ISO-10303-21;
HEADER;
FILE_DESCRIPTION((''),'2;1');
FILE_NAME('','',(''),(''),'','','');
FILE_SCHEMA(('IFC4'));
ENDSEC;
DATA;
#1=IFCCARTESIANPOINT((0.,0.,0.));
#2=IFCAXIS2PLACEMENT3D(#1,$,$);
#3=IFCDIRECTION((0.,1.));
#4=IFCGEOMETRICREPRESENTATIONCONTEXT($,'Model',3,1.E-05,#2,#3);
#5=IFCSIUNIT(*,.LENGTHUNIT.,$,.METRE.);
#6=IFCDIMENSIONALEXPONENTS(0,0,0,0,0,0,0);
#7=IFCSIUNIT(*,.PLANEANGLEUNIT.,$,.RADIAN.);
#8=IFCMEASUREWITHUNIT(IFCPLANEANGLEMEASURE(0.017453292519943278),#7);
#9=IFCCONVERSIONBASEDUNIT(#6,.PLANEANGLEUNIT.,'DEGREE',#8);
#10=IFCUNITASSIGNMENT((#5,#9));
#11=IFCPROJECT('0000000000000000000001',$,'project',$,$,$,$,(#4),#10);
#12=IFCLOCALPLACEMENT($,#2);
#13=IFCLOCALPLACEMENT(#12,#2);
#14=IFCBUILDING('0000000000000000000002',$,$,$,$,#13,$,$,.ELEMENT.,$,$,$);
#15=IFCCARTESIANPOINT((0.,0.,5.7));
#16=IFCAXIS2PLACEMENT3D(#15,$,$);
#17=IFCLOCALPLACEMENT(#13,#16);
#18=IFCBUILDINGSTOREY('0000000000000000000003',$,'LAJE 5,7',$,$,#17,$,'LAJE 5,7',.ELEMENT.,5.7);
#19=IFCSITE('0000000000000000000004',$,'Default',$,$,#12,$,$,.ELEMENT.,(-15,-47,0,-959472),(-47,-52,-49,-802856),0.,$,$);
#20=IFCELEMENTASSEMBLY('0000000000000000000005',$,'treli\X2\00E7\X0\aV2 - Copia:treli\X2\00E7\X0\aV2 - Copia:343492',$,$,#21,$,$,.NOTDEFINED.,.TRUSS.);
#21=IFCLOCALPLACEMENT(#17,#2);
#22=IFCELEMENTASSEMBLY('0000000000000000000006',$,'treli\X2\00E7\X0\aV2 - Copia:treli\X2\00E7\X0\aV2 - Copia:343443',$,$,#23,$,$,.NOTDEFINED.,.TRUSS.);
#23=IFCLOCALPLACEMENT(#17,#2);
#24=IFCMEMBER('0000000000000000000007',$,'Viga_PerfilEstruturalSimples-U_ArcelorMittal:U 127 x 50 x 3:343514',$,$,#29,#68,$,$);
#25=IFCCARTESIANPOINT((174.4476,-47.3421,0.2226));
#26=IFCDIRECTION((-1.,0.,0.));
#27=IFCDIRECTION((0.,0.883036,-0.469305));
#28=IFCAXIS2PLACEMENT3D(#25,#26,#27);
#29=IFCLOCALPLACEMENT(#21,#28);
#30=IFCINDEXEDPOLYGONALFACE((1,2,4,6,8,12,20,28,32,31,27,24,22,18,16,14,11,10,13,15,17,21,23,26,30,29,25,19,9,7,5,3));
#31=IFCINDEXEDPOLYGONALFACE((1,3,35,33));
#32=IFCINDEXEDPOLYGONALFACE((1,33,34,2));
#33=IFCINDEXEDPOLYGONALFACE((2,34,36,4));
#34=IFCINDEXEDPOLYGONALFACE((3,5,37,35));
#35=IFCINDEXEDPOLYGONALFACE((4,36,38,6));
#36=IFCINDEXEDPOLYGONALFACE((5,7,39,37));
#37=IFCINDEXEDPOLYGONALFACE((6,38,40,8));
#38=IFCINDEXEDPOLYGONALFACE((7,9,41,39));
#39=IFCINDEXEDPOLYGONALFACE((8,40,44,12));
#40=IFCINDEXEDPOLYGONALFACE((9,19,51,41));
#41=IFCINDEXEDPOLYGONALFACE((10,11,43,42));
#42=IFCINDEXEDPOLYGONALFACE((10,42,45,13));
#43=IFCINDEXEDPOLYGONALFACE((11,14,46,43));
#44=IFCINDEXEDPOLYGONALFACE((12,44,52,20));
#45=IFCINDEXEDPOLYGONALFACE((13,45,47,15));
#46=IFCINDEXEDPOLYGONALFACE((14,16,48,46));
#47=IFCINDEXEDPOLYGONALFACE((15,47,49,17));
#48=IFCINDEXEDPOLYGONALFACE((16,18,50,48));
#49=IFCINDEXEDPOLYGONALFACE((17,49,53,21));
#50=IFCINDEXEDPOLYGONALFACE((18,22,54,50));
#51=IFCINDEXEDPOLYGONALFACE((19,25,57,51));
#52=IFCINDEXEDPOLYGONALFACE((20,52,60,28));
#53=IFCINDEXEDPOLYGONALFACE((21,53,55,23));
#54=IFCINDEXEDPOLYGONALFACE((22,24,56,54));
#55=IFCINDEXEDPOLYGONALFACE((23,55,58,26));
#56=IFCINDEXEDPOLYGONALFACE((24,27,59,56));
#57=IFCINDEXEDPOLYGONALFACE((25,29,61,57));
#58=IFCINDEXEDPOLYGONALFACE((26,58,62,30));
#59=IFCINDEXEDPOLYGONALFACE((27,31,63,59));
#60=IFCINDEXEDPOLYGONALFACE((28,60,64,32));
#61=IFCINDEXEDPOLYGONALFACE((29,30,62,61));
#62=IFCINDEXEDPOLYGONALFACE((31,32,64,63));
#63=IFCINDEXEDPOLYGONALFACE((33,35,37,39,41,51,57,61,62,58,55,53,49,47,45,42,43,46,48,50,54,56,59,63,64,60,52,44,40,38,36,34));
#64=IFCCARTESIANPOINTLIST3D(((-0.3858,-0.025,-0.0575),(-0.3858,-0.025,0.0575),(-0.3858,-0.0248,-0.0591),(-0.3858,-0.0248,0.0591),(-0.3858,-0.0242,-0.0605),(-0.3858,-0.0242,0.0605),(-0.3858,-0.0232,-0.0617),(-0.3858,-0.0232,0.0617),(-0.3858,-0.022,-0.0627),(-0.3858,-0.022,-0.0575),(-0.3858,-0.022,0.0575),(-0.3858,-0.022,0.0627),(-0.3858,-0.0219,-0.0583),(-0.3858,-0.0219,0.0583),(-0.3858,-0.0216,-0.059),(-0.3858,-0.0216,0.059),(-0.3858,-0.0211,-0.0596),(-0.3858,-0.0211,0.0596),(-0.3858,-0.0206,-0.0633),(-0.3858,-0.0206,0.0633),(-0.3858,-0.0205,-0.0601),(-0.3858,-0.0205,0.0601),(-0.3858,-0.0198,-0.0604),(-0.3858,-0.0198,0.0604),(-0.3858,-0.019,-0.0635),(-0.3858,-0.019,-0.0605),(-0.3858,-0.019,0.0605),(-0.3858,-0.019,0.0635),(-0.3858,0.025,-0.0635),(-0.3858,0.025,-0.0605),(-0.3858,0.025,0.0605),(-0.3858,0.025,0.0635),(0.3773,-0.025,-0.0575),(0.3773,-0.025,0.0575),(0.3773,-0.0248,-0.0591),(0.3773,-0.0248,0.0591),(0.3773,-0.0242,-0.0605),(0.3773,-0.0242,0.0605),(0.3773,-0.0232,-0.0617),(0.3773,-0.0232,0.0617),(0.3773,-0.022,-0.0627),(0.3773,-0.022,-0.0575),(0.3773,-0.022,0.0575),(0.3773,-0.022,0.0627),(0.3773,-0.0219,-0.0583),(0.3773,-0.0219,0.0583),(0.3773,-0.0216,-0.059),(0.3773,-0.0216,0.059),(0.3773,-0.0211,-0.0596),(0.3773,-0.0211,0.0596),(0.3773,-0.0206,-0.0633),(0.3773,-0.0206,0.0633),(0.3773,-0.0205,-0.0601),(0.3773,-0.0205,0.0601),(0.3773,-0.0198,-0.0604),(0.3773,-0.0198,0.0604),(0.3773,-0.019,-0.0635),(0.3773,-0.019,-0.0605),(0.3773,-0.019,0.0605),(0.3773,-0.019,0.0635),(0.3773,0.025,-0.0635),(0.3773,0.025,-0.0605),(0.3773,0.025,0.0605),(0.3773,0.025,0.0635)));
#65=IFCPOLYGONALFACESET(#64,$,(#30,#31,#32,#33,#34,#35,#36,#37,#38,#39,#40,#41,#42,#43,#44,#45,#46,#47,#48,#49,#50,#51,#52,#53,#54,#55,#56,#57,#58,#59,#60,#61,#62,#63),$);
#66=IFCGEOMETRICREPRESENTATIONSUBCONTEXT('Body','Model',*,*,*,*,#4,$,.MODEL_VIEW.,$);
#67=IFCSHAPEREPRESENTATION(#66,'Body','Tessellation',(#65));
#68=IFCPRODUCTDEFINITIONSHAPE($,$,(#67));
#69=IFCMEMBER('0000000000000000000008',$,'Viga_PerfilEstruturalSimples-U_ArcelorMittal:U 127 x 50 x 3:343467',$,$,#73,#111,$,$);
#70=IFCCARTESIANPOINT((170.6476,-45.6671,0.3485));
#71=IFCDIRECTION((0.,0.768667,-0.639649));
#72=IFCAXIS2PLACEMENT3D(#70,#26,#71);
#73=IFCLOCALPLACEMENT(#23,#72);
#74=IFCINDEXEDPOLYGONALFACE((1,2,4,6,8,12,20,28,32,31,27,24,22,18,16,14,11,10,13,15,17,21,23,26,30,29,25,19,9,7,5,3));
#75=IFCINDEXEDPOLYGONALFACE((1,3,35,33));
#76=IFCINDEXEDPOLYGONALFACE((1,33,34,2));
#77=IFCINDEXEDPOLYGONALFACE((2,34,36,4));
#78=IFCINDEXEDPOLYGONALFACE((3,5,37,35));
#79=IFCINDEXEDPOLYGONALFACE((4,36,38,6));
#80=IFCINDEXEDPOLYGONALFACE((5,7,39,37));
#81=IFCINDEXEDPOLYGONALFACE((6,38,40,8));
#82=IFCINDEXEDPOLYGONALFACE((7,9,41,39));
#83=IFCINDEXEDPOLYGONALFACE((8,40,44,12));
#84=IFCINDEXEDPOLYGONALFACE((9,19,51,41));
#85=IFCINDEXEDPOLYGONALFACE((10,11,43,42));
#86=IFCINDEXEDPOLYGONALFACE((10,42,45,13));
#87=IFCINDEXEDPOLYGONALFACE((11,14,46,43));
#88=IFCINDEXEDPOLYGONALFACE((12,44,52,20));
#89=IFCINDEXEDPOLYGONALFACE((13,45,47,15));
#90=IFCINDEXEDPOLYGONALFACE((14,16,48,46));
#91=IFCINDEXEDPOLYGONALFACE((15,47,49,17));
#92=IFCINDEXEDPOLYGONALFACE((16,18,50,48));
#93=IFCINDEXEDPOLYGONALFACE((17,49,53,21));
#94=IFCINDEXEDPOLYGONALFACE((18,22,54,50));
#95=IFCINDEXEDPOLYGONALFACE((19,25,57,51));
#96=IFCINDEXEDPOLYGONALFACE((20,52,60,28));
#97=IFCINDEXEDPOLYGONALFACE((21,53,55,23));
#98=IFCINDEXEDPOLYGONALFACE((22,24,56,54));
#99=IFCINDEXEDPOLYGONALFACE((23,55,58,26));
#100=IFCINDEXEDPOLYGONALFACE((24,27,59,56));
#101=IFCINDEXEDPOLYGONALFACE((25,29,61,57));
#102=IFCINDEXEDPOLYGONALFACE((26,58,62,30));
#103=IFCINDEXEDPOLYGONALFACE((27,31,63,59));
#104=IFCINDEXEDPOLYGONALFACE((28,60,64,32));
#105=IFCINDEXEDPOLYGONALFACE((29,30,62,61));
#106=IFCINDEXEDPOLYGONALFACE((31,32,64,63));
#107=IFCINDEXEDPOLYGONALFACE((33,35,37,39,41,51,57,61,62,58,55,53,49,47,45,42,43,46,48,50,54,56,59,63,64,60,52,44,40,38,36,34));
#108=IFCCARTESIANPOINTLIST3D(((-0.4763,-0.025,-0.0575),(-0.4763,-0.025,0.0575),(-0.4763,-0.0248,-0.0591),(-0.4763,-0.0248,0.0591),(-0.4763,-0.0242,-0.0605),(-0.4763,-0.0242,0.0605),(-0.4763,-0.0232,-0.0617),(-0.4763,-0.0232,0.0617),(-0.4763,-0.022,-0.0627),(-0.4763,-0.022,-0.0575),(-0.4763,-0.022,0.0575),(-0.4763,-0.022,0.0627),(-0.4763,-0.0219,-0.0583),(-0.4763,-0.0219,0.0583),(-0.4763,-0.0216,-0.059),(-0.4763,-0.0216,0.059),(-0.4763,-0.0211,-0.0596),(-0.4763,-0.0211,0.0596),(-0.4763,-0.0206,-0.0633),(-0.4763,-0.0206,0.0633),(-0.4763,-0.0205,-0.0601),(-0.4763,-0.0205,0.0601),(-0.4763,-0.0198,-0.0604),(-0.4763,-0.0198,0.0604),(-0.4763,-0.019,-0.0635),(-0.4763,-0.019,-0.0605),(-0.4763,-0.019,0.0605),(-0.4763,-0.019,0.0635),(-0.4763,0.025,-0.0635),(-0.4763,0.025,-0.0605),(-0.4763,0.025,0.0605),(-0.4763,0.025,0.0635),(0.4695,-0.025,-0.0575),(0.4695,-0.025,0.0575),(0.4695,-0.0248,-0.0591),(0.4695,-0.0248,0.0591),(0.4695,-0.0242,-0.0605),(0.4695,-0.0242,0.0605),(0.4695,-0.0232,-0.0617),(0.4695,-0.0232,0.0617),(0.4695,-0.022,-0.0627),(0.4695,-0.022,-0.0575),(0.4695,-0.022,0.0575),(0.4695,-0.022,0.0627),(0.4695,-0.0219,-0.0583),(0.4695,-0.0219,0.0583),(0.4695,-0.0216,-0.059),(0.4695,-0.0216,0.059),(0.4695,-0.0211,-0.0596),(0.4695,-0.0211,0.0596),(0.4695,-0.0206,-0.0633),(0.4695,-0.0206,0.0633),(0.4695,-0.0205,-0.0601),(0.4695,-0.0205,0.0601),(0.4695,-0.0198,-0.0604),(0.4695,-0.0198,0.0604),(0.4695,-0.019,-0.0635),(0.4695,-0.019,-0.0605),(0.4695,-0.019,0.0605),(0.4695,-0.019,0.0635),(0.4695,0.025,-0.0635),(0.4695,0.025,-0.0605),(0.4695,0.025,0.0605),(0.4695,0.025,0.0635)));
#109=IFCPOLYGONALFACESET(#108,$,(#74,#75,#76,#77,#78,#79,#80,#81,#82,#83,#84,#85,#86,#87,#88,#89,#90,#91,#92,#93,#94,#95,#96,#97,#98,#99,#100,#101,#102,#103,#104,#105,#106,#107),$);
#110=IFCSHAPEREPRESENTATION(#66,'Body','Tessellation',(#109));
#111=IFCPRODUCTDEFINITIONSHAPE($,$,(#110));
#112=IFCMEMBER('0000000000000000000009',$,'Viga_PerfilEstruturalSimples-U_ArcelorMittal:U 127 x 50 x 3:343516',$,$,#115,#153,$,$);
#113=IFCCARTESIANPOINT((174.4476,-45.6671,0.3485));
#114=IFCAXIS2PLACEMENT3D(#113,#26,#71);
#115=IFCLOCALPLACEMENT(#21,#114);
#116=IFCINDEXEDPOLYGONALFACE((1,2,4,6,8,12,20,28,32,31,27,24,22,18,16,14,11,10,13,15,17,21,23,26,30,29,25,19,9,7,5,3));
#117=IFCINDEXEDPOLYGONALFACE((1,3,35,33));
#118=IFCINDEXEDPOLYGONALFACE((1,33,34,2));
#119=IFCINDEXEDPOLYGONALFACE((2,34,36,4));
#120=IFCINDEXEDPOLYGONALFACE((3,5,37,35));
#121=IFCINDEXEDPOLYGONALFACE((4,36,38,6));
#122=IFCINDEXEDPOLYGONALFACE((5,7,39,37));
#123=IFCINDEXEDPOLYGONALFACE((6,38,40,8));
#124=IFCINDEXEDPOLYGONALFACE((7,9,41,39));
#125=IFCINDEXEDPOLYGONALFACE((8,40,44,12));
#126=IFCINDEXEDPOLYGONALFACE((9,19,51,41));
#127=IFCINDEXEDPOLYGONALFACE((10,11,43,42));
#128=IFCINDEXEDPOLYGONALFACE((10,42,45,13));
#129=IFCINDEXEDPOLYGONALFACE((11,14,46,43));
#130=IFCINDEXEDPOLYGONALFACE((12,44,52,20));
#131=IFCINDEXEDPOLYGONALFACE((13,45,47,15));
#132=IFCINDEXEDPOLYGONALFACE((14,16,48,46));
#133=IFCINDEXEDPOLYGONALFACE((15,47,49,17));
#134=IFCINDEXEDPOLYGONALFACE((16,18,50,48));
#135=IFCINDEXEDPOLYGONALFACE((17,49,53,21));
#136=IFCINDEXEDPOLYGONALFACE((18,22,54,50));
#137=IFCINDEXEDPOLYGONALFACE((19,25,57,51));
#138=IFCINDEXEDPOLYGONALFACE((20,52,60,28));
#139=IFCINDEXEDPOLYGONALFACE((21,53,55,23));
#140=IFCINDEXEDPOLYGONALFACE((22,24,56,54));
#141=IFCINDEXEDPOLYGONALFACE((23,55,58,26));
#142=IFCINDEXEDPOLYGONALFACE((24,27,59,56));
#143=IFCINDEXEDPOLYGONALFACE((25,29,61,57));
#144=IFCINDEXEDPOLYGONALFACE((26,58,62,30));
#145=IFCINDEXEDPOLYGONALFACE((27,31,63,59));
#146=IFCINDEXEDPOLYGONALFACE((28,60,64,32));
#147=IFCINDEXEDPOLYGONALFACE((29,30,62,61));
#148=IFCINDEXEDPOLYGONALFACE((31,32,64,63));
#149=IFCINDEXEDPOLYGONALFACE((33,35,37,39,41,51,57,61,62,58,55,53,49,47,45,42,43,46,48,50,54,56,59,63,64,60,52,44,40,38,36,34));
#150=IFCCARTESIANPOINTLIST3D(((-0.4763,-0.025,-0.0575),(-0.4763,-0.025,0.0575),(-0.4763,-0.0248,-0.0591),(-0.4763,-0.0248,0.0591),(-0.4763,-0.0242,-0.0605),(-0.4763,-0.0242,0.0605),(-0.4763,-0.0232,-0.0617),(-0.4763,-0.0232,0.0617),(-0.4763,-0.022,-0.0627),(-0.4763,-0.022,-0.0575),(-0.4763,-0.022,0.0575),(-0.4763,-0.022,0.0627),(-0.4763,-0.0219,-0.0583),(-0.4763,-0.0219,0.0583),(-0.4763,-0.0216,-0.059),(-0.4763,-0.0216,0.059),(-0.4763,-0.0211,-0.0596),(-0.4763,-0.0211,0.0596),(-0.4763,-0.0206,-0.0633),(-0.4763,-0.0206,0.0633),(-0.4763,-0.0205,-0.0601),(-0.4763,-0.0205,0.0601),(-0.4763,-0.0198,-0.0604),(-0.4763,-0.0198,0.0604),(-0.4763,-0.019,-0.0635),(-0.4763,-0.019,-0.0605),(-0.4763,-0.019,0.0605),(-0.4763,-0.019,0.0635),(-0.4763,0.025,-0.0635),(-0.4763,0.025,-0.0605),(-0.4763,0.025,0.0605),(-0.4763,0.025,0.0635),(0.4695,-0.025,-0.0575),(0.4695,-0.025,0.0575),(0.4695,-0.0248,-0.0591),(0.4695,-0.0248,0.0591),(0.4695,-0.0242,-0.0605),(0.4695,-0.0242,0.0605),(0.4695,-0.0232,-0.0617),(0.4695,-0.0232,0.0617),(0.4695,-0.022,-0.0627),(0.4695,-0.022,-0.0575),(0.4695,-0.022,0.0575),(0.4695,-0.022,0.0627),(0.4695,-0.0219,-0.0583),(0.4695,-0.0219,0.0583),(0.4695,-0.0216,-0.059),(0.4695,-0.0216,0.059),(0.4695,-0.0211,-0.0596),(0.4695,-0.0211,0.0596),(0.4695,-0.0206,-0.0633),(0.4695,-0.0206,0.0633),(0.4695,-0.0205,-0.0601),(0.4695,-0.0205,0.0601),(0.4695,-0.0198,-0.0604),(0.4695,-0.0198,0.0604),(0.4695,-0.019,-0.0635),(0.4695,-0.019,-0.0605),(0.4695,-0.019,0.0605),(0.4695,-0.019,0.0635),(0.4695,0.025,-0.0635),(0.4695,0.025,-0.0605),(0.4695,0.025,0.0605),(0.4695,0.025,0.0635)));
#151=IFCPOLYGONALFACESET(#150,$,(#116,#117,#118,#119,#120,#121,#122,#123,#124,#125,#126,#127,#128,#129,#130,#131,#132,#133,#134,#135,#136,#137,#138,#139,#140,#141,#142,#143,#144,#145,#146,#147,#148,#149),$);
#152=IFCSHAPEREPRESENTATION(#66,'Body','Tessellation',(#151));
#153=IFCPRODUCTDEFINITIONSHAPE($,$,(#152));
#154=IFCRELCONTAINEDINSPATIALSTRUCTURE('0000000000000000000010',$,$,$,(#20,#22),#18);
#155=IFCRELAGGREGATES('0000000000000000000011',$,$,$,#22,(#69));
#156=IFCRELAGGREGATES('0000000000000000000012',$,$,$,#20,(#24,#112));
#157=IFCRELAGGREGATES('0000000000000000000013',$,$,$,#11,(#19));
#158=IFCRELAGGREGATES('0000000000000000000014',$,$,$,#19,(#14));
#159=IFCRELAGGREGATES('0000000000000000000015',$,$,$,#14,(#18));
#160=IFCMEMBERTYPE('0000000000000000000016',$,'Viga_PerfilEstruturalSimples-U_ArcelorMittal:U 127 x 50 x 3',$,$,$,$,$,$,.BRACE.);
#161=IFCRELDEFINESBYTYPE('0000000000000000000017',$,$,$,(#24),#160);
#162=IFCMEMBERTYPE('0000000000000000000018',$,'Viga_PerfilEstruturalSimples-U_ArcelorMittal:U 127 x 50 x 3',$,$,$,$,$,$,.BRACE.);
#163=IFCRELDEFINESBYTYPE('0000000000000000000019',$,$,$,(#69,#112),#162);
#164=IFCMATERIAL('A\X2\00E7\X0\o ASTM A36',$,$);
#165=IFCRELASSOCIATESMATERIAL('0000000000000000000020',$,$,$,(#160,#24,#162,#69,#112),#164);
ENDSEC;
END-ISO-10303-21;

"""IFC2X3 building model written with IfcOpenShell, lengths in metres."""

from ifc_helpers import new_model, entity, si_unit, converted_unit, direction, frame, frame_2d, origin, place, context, subcontext, project, spatial, polyline, circle_curve, parameter, trimmed, segment, composite_curve, outline, extrude, source, transform, mapped, material, type_object, type_shapes, element, aggregate, save


model = new_model("IFC2X3")

# Units and contexts
model_context = context("Model", 3, precision=1e-05, world=origin(), true_north=direction((0.0, 1.0)))
body_context = subcontext(model_context, "Body", "Model", "MODEL_VIEW")
ifc_project = project(units=[si_unit("LENGTHUNIT", "METRE"), converted_unit("PLANEANGLEUNIT", "DEGREE", entity("IfcPlaneAngleMeasure", 0.017453292519943278), si_unit("PLANEANGLEUNIT", "RADIAN"), dimensions=[0, 0, 0, 0, 0, 0, 0])], contexts=[model_context])

# Site, building, storey
site_placement = place(None, origin())
site = spatial("IfcSite", under=ifc_project, at=site_placement, Name="Default", CompositionType="ELEMENT", RefLatitude=(-15, -47, 0, -959472), RefLongitude=(-47, -52, -49, -802856), RefElevation=0.0)
building_placement = place(site_placement, origin())
building = spatial("IfcBuilding", under=site, at=building_placement, CompositionType="ELEMENT")
storey_placement = place(building_placement, frame((0.0, 0.0, 5.7)))
storey = spatial("IfcBuildingStorey", under=building, at=storey_placement, Name="LAJE 5,7", LongName="LAJE 5,7", CompositionType="ELEMENT", Elevation=5.7)

# Element assembly
assembly_1_placement = place(storey_placement, origin())
assembly_1 = element("IfcElementAssembly", 1, at=assembly_1_placement, inside=storey, Name="treliçaV2 - Copia:treliçaV2 - Copia:343492", AssemblyPlace="NOTDEFINED", PredefinedType="TRUSS")
ifc_material = material(Name="Aço ASTM A36")

# Element assembly
assembly_2_placement = place(storey_placement, origin())
assembly_2 = element("IfcElementAssembly", 2, at=assembly_2_placement, inside=storey, Name="treliçaV2 - Copia:treliçaV2 - Copia:343443", AssemblyPlace="NOTDEFINED", PredefinedType="TRUSS")

# Members
member_type_1 = type_object("IfcMemberType", Name="Viga_PerfilEstruturalSimples-U_ArcelorMittal:U 127 x 50 x 3", PredefinedType="BRACE", material=ifc_material)
shared_shape_1 = source(origin(), body_context, "Body", "SweptSolid", [
    extrude(outline(composite_curve([segment(polyline([(-0.0575, -0.0192), (0.0575, -0.0192)]), True, "CONTINUOUS"), segment(trimmed(circle_curve(frame_2d((0.0575, -0.0132), x_axis=(0.0, 1.0)), 0.006), [parameter(180.0)], [parameter(270.0)], True, "PARAMETER"), True, "CONTINUOUS"), segment(polyline([(0.0635, -0.0132), (0.0635, 0.0308)]), True, "CONTINUOUS"), segment(polyline([(0.0635, 0.0308), (0.0605, 0.0308)]), True, "CONTINUOUS"), segment(polyline([(0.0605, 0.0308), (0.0605, -0.0132)]), True, "CONTINUOUS"), segment(trimmed(circle_curve(frame_2d((0.0575, -0.0132), x_axis=(0.0, 1.0)), 0.003), [parameter(180.0)], [parameter(270.0)], True, "PARAMETER"), False, "CONTINUOUS"), segment(polyline([(0.0575, -0.0162), (-0.0575, -0.0162)]), True, "CONTINUOUS"), segment(trimmed(circle_curve(frame_2d((-0.0575, -0.0132), x_axis=(0.0, 1.0)), 0.003), [parameter(90.0)], [parameter(180.0)], True, "PARAMETER"), False, "CONTINUOUS"), segment(polyline([(-0.0605, -0.0132), (-0.0605, 0.0308)]), True, "CONTINUOUS"), segment(polyline([(-0.0605, 0.0308), (-0.0635, 0.0308)]), True, "CONTINUOUS"), segment(polyline([(-0.0635, 0.0308), (-0.0635, -0.0132)]), True, "CONTINUOUS"), segment(trimmed(circle_curve(frame_2d((-0.0575, -0.0132), x_axis=(0.0, 1.0)), 0.006), [parameter(90.0)], [parameter(180.0)], True, "PARAMETER"), True, "CONTINUOUS")], self_intersect=False)), frame((-0.3858, -0.0058, 0.0), z_axis=(1.0, 0.0, 0.0), x_axis=(0.0, 0.0, -1.0)), (0.0, 0.0, 1.0), 0.7631),
])
type_shapes(member_type_1, [shared_shape_1])
member_1_placement = place(assembly_1_placement, frame((174.4476, -47.3421, 0.2226), z_axis=(-1.0, 0.0, 0.0), x_axis=(0.0, 0.883036, -0.469305)))
member_1 = element("IfcMember", 3, at=member_1_placement, type_object=member_type_1, material=ifc_material, Name="Viga_PerfilEstruturalSimples-U_ArcelorMittal:U 127 x 50 x 3:343514", context=body_context, shape_type="MappedRepresentation", body=[
    mapped(shared_shape_1, transform((0.0, 0.0, 0.0), scale=1.0)),
])
member_type_2 = type_object("IfcMemberType", Name="Viga_PerfilEstruturalSimples-U_ArcelorMittal:U 127 x 50 x 3", PredefinedType="BRACE", material=ifc_material)
shared_shape_2 = source(origin(), body_context, "Body", "SweptSolid", [
    extrude(outline(composite_curve([segment(polyline([(-0.0575, -0.0192), (0.0575, -0.0192)]), True, "CONTINUOUS"), segment(trimmed(circle_curve(frame_2d((0.0575, -0.0132), x_axis=(0.0, 1.0)), 0.006), [parameter(180.0)], [parameter(270.0)], True, "PARAMETER"), True, "CONTINUOUS"), segment(polyline([(0.0635, -0.0132), (0.0635, 0.0308)]), True, "CONTINUOUS"), segment(polyline([(0.0635, 0.0308), (0.0605, 0.0308)]), True, "CONTINUOUS"), segment(polyline([(0.0605, 0.0308), (0.0605, -0.0132)]), True, "CONTINUOUS"), segment(trimmed(circle_curve(frame_2d((0.0575, -0.0132), x_axis=(0.0, 1.0)), 0.003), [parameter(180.0)], [parameter(270.0)], True, "PARAMETER"), False, "CONTINUOUS"), segment(polyline([(0.0575, -0.0162), (-0.0575, -0.0162)]), True, "CONTINUOUS"), segment(trimmed(circle_curve(frame_2d((-0.0575, -0.0132), x_axis=(0.0, 1.0)), 0.003), [parameter(90.0)], [parameter(180.0)], True, "PARAMETER"), False, "CONTINUOUS"), segment(polyline([(-0.0605, -0.0132), (-0.0605, 0.0308)]), True, "CONTINUOUS"), segment(polyline([(-0.0605, 0.0308), (-0.0635, 0.0308)]), True, "CONTINUOUS"), segment(polyline([(-0.0635, 0.0308), (-0.0635, -0.0132)]), True, "CONTINUOUS"), segment(trimmed(circle_curve(frame_2d((-0.0575, -0.0132), x_axis=(0.0, 1.0)), 0.006), [parameter(90.0)], [parameter(180.0)], True, "PARAMETER"), True, "CONTINUOUS")], self_intersect=False)), frame((-0.4763, -0.0058, 0.0), z_axis=(1.0, 0.0, 0.0), x_axis=(0.0, 0.0, -1.0)), (0.0, 0.0, 1.0), 0.9459),
])
type_shapes(member_type_2, [shared_shape_2])
member_2_placement = place(assembly_2_placement, frame((170.6476, -45.6671, 0.3485), z_axis=(-1.0, 0.0, 0.0), x_axis=(0.0, 0.768667, -0.639649)))
member_2 = element("IfcMember", 4, at=member_2_placement, type_object=member_type_2, material=ifc_material, Name="Viga_PerfilEstruturalSimples-U_ArcelorMittal:U 127 x 50 x 3:343467", context=body_context, shape_type="MappedRepresentation", body=[
    mapped(shared_shape_2, transform((0.0, 0.0, 0.0), scale=1.0)),
])
member_3_placement = place(assembly_1_placement, frame((174.4476, -45.6671, 0.3485), z_axis=(-1.0, 0.0, 0.0), x_axis=(0.0, 0.768667, -0.639649)))
member_3 = element("IfcMember", 5, at=member_3_placement, type_object=member_type_2, material=ifc_material, Name="Viga_PerfilEstruturalSimples-U_ArcelorMittal:U 127 x 50 x 3:343516", context=body_context, shape_type="MappedRepresentation", body=[
    mapped(shared_shape_2, transform((0.0, 0.0, 0.0), scale=1.0)),
])
aggregate(assembly_2, [member_2])
aggregate(assembly_1, [member_1, member_3])

save(model, "model.ifc")
